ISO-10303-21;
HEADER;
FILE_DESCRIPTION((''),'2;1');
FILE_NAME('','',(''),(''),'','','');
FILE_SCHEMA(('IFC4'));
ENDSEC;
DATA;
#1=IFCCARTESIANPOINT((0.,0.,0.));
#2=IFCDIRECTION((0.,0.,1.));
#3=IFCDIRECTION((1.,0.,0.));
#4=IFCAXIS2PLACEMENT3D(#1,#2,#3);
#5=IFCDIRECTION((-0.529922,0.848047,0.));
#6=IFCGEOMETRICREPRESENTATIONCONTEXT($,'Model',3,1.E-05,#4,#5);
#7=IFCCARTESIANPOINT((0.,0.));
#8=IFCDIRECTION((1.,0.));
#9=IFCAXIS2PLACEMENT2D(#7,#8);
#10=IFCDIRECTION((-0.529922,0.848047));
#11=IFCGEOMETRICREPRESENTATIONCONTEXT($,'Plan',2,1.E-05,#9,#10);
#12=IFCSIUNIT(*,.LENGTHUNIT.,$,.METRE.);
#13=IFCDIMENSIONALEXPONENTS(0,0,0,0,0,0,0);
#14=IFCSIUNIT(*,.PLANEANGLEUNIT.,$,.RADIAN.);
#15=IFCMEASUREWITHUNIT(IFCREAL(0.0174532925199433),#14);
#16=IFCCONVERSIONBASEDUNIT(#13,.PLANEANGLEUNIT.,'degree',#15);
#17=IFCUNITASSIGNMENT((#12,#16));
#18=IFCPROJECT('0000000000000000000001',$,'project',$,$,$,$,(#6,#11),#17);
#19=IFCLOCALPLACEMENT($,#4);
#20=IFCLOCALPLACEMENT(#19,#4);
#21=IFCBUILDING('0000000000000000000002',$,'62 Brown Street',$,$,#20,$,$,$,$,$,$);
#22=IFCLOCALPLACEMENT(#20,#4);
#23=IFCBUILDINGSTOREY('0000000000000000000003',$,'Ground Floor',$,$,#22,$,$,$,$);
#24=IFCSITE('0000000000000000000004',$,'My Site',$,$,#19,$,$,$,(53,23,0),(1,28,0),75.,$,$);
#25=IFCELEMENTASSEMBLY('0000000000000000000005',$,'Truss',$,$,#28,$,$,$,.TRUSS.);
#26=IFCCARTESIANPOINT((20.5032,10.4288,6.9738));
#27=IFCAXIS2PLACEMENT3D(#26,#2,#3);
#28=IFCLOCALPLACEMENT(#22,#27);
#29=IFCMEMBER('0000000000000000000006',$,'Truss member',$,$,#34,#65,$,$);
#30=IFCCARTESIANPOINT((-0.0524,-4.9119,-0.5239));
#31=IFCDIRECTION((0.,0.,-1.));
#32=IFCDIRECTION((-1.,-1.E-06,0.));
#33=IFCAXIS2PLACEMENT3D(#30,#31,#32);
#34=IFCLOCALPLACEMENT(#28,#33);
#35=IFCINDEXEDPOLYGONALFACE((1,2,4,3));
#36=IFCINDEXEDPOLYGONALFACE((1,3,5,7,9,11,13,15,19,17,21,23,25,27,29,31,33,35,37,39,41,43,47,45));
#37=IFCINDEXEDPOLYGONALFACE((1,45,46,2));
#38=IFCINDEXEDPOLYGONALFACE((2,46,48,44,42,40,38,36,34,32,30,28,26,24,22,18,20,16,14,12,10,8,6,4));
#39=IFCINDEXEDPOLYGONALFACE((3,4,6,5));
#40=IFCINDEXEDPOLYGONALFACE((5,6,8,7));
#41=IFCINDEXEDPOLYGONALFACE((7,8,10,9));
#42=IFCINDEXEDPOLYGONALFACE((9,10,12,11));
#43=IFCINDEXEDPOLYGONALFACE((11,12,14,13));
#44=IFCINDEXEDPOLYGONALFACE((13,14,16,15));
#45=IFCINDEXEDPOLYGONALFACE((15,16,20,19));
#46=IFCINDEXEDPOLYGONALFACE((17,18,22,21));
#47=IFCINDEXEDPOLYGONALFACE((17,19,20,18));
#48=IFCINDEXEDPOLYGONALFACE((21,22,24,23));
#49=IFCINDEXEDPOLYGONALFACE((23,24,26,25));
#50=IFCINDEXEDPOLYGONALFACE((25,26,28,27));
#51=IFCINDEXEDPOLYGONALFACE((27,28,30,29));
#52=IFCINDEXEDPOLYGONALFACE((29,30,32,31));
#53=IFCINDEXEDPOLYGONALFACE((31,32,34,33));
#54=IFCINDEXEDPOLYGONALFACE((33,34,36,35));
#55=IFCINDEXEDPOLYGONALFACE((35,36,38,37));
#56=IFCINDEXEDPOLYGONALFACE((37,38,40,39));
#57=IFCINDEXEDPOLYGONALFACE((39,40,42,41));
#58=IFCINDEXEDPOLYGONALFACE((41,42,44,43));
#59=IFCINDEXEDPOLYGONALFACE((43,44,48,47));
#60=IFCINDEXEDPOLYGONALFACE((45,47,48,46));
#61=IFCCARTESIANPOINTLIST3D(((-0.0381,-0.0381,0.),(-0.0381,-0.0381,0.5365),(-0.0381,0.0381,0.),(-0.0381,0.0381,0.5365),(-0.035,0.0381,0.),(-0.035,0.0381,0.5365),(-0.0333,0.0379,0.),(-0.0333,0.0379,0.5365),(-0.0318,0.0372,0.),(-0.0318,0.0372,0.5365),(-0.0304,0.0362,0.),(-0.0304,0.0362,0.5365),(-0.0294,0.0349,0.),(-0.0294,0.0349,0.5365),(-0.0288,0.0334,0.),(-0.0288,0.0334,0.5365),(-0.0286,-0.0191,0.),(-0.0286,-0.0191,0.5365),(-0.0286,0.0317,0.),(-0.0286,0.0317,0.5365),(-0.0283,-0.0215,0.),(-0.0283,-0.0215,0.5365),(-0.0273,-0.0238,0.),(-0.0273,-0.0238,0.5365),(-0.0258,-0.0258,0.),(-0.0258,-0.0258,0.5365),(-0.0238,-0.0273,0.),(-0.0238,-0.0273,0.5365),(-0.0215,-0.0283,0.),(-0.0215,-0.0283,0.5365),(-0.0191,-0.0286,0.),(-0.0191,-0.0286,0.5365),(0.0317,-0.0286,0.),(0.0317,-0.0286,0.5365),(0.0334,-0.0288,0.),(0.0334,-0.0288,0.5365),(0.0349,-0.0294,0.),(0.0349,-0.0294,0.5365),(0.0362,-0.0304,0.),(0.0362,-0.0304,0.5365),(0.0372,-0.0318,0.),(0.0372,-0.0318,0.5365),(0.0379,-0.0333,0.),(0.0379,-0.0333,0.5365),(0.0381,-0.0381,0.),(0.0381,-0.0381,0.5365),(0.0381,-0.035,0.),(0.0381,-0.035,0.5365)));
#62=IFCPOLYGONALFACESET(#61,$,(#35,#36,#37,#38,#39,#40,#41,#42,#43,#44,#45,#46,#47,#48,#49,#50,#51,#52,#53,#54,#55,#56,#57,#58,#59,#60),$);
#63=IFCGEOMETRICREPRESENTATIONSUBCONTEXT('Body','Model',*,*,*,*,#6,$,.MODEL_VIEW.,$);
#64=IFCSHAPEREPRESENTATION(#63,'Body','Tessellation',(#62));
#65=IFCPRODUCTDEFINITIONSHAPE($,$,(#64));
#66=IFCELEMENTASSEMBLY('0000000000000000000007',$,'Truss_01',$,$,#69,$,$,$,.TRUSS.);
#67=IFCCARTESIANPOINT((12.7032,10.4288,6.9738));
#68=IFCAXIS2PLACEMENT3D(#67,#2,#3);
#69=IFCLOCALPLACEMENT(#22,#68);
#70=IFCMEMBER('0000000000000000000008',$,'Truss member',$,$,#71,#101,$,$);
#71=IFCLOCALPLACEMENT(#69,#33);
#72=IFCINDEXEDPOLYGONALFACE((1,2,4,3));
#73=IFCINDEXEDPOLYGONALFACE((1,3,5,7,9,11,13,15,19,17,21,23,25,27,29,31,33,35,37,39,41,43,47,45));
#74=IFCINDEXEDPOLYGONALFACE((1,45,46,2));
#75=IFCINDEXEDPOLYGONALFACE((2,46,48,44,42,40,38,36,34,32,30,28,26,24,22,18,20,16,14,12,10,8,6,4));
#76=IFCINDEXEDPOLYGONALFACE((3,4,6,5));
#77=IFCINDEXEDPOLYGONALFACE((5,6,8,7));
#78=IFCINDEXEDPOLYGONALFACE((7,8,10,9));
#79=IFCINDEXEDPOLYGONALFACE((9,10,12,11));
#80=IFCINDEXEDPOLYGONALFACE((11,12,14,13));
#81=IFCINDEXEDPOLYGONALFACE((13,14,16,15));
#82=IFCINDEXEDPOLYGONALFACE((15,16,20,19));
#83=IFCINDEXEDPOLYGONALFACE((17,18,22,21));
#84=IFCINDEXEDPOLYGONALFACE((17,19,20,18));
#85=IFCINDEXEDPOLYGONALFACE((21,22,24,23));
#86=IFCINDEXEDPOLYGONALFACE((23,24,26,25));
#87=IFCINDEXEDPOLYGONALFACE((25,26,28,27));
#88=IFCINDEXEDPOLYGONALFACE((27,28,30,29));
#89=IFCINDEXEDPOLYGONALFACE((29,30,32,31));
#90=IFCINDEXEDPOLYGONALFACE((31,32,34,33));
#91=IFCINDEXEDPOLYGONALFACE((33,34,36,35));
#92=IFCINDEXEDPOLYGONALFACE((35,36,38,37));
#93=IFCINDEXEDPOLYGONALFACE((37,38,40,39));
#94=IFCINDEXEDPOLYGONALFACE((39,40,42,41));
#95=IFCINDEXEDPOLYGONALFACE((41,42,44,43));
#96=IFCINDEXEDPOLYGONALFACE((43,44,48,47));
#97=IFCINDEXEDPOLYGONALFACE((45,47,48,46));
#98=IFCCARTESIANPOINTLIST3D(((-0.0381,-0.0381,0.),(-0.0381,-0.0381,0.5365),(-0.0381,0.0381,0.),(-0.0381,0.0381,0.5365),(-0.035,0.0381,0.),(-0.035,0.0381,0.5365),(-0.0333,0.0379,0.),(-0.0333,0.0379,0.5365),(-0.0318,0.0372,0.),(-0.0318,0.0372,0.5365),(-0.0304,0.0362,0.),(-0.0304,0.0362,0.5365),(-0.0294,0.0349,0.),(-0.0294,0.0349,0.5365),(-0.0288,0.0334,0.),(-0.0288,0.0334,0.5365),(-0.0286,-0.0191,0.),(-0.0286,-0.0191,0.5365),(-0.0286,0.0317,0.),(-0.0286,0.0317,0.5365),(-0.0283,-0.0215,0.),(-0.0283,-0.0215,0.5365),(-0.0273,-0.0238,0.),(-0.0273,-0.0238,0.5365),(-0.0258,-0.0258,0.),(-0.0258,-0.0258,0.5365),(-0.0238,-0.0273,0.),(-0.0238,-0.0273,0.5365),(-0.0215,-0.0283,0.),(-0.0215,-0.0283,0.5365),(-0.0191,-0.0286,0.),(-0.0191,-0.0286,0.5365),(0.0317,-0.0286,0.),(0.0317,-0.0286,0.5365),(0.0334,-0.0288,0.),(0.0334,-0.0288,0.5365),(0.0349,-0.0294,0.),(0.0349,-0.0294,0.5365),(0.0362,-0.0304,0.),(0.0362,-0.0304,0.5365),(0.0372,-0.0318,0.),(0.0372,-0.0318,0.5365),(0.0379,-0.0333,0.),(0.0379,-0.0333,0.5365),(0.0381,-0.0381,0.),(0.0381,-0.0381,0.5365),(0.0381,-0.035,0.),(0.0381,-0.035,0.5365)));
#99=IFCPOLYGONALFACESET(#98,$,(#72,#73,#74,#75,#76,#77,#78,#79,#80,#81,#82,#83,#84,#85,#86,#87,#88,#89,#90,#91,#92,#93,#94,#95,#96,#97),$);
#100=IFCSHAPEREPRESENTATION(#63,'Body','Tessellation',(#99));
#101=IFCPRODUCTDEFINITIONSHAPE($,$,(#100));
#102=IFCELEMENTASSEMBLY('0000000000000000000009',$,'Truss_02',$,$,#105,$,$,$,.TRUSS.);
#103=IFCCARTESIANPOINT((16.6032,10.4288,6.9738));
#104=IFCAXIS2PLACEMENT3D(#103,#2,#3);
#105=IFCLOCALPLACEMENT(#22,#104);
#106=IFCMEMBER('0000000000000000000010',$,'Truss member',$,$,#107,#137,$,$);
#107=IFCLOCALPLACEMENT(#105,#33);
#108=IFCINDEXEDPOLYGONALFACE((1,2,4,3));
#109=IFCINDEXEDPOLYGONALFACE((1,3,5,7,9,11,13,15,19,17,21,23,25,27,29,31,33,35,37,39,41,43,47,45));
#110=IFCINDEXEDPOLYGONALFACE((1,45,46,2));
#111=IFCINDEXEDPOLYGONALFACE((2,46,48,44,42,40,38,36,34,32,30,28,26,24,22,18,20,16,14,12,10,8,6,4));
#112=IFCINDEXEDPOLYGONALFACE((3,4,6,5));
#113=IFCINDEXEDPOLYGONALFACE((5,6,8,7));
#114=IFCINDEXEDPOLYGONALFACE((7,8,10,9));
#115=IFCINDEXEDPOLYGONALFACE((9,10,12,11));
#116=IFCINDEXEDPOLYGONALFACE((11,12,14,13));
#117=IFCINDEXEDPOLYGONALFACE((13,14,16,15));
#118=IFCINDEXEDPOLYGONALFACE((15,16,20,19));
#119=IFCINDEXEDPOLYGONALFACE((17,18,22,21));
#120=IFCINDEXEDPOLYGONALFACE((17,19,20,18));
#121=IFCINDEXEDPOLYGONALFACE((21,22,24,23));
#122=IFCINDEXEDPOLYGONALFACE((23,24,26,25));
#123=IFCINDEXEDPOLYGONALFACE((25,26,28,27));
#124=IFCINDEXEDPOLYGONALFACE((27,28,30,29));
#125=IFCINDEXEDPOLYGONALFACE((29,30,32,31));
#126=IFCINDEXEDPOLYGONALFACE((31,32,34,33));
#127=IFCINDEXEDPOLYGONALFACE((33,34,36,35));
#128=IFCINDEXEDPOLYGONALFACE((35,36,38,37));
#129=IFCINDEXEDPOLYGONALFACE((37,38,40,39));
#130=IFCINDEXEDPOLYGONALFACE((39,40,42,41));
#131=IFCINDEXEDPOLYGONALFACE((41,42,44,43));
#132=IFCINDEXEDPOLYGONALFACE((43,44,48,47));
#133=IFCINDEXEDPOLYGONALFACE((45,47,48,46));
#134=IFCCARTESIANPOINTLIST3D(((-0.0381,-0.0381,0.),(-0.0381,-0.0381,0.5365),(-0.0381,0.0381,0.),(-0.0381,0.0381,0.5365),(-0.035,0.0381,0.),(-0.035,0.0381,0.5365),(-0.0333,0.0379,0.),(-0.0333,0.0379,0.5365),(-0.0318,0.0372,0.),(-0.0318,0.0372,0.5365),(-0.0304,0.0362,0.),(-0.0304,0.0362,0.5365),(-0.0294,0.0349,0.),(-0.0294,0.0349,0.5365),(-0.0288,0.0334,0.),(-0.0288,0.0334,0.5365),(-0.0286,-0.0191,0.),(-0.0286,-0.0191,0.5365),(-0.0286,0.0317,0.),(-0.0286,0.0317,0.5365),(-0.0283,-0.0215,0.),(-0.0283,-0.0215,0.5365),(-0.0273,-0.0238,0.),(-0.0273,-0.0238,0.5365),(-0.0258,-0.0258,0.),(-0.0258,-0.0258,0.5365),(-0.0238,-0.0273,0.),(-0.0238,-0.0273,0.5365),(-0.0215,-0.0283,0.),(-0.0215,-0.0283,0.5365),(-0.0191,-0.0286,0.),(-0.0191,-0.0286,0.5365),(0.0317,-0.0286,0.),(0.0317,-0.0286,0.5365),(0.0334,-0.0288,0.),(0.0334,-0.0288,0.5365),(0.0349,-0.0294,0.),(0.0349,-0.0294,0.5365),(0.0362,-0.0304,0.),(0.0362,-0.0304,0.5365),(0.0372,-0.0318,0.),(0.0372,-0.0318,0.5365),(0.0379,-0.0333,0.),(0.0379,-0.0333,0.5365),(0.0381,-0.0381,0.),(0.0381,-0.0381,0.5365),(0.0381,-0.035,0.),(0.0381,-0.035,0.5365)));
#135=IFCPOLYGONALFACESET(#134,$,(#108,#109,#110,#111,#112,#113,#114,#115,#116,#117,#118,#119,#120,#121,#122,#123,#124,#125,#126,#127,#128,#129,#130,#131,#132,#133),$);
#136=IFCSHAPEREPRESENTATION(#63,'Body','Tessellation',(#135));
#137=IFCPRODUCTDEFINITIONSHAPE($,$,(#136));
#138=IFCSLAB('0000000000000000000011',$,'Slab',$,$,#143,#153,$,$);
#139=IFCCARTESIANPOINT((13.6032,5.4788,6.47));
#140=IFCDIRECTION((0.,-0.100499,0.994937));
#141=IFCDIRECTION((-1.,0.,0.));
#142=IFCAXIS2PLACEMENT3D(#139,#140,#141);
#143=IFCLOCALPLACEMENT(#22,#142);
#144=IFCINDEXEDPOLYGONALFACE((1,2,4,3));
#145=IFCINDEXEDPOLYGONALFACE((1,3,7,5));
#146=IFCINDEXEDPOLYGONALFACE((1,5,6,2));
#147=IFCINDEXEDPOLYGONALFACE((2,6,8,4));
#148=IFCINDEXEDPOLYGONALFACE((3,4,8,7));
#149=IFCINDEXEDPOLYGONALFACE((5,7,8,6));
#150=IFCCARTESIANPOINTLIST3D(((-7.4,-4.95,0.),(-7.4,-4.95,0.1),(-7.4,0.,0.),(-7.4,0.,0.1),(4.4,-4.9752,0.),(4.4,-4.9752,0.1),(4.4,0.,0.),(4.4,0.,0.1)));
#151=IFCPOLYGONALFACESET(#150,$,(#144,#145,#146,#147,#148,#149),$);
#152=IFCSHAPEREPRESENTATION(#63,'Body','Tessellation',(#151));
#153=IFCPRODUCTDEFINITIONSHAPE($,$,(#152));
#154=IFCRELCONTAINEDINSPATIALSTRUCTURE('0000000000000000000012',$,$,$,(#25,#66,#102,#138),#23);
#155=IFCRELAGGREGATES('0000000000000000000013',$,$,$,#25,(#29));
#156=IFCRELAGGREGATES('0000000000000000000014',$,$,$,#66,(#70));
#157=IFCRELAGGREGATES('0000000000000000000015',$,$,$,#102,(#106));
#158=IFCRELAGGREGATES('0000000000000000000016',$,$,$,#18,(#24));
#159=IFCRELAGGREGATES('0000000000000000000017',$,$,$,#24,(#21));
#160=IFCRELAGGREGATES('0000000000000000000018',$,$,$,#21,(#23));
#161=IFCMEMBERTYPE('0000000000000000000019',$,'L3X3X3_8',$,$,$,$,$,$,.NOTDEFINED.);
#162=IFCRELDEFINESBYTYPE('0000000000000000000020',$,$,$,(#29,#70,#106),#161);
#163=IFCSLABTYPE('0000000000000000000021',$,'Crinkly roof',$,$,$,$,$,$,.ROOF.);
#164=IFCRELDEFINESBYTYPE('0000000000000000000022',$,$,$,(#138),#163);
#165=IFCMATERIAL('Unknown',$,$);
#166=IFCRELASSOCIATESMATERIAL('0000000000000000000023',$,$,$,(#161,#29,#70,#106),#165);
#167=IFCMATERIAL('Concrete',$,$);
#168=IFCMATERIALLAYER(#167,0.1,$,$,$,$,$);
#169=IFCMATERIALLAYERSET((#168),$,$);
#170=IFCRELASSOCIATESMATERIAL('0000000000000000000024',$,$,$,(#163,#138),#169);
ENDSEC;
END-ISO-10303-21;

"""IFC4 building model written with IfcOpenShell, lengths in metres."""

from ifc_helpers import new_model, entity, si_unit, converted_unit, direction, frame, origin_with_axes, origin_2d_with_axis, place, context, subcontext, project, spatial, indexed_curve, l_section, outline, extrude, material, layer, layer_set, layer_usage, material_profile, profile_set, profile_usage, type_object, element, aggregate, save


model = new_model("IFC4")

# Units and contexts
model_context = context("Model", 3, precision=1e-05, world=origin_with_axes(), true_north=direction((-0.529922, 0.848047, 0.0)))
plan_context = context("Plan", 2, precision=1e-05, world=origin_2d_with_axis(), true_north=direction((-0.529922, 0.848047)))
body_context_1 = subcontext(model_context, "Body", "Model", "MODEL_VIEW")
ifc_project = project(units=[si_unit("LENGTHUNIT", "METRE"), converted_unit("PLANEANGLEUNIT", "degree", entity("IfcReal", 0.0174532925199433), si_unit("PLANEANGLEUNIT", "RADIAN"), dimensions=[0, 0, 0, 0, 0, 0, 0])], contexts=[model_context, plan_context])

# Site, building, storey
site_placement = place(None, origin_with_axes())
site = spatial("IfcSite", under=ifc_project, at=site_placement, Name="My Site", RefLatitude=(53, 23, 0), RefLongitude=(1, 28, 0), RefElevation=75.0)
building_placement = place(site_placement, origin_with_axes())
building = spatial("IfcBuilding", under=site, at=building_placement, Name="62 Brown Street")
storey_placement = place(building_placement, origin_with_axes())
storey = spatial("IfcBuildingStorey", under=building, at=storey_placement, Name="Ground Floor")

# Element assemblies, members
assembly_1_placement = place(storey_placement, frame((20.5032, 10.4288, 6.9738), z_axis=(0.0, 0.0, 1.0), x_axis=(1.0, 0.0, 0.0)))
assembly_1 = element("IfcElementAssembly", 1, at=assembly_1_placement, inside=storey, Name="Truss", PredefinedType="TRUSS")
ifc_material_1 = material(Name="Unknown")
ifc_material_profile_1 = material_profile(ifc_material_1, l_section(Depth=0.0762, Width=0.0762, Thickness=0.0095, FilletRadius=0.0095, EdgeRadius=0.0064))
ifc_profile_set_1 = profile_set([ifc_material_profile_1])
member_type_1 = type_object("IfcMemberType", Name="L3X3X3_8", PredefinedType="NOTDEFINED", material=ifc_profile_set_1)
ifc_profile_usage_1 = profile_usage(ifc_profile_set_1, cardinal=5)
member_1_placement = place(assembly_1_placement, frame((-0.0524, -4.9119, -0.5239), z_axis=(0.0, 0.0, -1.0), x_axis=(-1.0, -0.000001, 0.0)))
member_1 = element("IfcMember", 2, at=member_1_placement, type_object=member_type_1, material=ifc_profile_usage_1, Name="Truss member", context=body_context_1, shape_type="SweptSolid", body=[
    extrude(l_section(Depth=0.0762, Width=0.0762, Thickness=0.0095, FilletRadius=0.0095, EdgeRadius=0.0064), origin_with_axes(), (0.0, 0.0, 1.0), 0.5365),
])
aggregate(assembly_1, [member_1])
assembly_2_placement = place(storey_placement, frame((12.7032, 10.4288, 6.9738), z_axis=(0.0, 0.0, 1.0), x_axis=(1.0, 0.0, 0.0)))
assembly_2 = element("IfcElementAssembly", 3, at=assembly_2_placement, inside=storey, Name="Truss_01", PredefinedType="TRUSS")
ifc_profile_usage_2 = profile_usage(ifc_profile_set_1, cardinal=5)
member_2_placement = place(assembly_2_placement, frame((-0.0524, -4.9119, -0.5239), z_axis=(0.0, 0.0, -1.0), x_axis=(-1.0, -0.000001, 0.0)))
member_2 = element("IfcMember", 4, at=member_2_placement, type_object=member_type_1, material=ifc_profile_usage_2, Name="Truss member", context=body_context_1, shape_type="SweptSolid", body=[
    extrude(l_section(Depth=0.0762, Width=0.0762, Thickness=0.0095, FilletRadius=0.0095, EdgeRadius=0.0064), origin_with_axes(), (0.0, 0.0, 1.0), 0.5365),
])
assembly_3_placement = place(storey_placement, frame((16.6032, 10.4288, 6.9738), z_axis=(0.0, 0.0, 1.0), x_axis=(1.0, 0.0, 0.0)))
assembly_3 = element("IfcElementAssembly", 5, at=assembly_3_placement, inside=storey, Name="Truss_02", PredefinedType="TRUSS")
ifc_profile_usage_3 = profile_usage(ifc_profile_set_1, cardinal=5)
member_3_placement = place(assembly_3_placement, frame((-0.0524, -4.9119, -0.5239), z_axis=(0.0, 0.0, -1.0), x_axis=(-1.0, -0.000001, 0.0)))
member_3 = element("IfcMember", 6, at=member_3_placement, type_object=member_type_1, material=ifc_profile_usage_3, Name="Truss member", context=body_context_1, shape_type="SweptSolid", body=[
    extrude(l_section(Depth=0.0762, Width=0.0762, Thickness=0.0095, FilletRadius=0.0095, EdgeRadius=0.0064), origin_with_axes(), (0.0, 0.0, 1.0), 0.5365),
])

aggregate(assembly_2, [member_2])
aggregate(assembly_3, [member_3])

# Slab
ifc_material_2 = material(Name="Concrete")
ifc_layer_1 = layer(ifc_material_2, 0.1)
ifc_layer_set_1 = layer_set([ifc_layer_1])
ifc_layer_usage_1 = layer_usage(ifc_layer_set_1, "AXIS3", "POSITIVE", 0.0)
slab_type = type_object("IfcSlabType", Name="Crinkly roof", PredefinedType="ROOF", material=ifc_layer_set_1)
slab_placement = place(storey_placement, frame((13.6032, 5.4788, 6.47), z_axis=(0.0, -0.100499, 0.994937), x_axis=(-1.0, 0.0, 0.0)))
element("IfcSlab", 7, at=slab_placement, inside=storey, type_object=slab_type, material=ifc_layer_usage_1, Name="Slab", context=body_context_1, shape_type="SweptSolid", body=[
    extrude(outline(indexed_curve([(4.4, 0.0), (-7.4, 0.0), (-7.4, -4.95), (4.4, -4.9752), (4.4, 0.0)])), None, (0.0, 0.0, 1.0), 0.1),
])

save(model, "model.ifc")
